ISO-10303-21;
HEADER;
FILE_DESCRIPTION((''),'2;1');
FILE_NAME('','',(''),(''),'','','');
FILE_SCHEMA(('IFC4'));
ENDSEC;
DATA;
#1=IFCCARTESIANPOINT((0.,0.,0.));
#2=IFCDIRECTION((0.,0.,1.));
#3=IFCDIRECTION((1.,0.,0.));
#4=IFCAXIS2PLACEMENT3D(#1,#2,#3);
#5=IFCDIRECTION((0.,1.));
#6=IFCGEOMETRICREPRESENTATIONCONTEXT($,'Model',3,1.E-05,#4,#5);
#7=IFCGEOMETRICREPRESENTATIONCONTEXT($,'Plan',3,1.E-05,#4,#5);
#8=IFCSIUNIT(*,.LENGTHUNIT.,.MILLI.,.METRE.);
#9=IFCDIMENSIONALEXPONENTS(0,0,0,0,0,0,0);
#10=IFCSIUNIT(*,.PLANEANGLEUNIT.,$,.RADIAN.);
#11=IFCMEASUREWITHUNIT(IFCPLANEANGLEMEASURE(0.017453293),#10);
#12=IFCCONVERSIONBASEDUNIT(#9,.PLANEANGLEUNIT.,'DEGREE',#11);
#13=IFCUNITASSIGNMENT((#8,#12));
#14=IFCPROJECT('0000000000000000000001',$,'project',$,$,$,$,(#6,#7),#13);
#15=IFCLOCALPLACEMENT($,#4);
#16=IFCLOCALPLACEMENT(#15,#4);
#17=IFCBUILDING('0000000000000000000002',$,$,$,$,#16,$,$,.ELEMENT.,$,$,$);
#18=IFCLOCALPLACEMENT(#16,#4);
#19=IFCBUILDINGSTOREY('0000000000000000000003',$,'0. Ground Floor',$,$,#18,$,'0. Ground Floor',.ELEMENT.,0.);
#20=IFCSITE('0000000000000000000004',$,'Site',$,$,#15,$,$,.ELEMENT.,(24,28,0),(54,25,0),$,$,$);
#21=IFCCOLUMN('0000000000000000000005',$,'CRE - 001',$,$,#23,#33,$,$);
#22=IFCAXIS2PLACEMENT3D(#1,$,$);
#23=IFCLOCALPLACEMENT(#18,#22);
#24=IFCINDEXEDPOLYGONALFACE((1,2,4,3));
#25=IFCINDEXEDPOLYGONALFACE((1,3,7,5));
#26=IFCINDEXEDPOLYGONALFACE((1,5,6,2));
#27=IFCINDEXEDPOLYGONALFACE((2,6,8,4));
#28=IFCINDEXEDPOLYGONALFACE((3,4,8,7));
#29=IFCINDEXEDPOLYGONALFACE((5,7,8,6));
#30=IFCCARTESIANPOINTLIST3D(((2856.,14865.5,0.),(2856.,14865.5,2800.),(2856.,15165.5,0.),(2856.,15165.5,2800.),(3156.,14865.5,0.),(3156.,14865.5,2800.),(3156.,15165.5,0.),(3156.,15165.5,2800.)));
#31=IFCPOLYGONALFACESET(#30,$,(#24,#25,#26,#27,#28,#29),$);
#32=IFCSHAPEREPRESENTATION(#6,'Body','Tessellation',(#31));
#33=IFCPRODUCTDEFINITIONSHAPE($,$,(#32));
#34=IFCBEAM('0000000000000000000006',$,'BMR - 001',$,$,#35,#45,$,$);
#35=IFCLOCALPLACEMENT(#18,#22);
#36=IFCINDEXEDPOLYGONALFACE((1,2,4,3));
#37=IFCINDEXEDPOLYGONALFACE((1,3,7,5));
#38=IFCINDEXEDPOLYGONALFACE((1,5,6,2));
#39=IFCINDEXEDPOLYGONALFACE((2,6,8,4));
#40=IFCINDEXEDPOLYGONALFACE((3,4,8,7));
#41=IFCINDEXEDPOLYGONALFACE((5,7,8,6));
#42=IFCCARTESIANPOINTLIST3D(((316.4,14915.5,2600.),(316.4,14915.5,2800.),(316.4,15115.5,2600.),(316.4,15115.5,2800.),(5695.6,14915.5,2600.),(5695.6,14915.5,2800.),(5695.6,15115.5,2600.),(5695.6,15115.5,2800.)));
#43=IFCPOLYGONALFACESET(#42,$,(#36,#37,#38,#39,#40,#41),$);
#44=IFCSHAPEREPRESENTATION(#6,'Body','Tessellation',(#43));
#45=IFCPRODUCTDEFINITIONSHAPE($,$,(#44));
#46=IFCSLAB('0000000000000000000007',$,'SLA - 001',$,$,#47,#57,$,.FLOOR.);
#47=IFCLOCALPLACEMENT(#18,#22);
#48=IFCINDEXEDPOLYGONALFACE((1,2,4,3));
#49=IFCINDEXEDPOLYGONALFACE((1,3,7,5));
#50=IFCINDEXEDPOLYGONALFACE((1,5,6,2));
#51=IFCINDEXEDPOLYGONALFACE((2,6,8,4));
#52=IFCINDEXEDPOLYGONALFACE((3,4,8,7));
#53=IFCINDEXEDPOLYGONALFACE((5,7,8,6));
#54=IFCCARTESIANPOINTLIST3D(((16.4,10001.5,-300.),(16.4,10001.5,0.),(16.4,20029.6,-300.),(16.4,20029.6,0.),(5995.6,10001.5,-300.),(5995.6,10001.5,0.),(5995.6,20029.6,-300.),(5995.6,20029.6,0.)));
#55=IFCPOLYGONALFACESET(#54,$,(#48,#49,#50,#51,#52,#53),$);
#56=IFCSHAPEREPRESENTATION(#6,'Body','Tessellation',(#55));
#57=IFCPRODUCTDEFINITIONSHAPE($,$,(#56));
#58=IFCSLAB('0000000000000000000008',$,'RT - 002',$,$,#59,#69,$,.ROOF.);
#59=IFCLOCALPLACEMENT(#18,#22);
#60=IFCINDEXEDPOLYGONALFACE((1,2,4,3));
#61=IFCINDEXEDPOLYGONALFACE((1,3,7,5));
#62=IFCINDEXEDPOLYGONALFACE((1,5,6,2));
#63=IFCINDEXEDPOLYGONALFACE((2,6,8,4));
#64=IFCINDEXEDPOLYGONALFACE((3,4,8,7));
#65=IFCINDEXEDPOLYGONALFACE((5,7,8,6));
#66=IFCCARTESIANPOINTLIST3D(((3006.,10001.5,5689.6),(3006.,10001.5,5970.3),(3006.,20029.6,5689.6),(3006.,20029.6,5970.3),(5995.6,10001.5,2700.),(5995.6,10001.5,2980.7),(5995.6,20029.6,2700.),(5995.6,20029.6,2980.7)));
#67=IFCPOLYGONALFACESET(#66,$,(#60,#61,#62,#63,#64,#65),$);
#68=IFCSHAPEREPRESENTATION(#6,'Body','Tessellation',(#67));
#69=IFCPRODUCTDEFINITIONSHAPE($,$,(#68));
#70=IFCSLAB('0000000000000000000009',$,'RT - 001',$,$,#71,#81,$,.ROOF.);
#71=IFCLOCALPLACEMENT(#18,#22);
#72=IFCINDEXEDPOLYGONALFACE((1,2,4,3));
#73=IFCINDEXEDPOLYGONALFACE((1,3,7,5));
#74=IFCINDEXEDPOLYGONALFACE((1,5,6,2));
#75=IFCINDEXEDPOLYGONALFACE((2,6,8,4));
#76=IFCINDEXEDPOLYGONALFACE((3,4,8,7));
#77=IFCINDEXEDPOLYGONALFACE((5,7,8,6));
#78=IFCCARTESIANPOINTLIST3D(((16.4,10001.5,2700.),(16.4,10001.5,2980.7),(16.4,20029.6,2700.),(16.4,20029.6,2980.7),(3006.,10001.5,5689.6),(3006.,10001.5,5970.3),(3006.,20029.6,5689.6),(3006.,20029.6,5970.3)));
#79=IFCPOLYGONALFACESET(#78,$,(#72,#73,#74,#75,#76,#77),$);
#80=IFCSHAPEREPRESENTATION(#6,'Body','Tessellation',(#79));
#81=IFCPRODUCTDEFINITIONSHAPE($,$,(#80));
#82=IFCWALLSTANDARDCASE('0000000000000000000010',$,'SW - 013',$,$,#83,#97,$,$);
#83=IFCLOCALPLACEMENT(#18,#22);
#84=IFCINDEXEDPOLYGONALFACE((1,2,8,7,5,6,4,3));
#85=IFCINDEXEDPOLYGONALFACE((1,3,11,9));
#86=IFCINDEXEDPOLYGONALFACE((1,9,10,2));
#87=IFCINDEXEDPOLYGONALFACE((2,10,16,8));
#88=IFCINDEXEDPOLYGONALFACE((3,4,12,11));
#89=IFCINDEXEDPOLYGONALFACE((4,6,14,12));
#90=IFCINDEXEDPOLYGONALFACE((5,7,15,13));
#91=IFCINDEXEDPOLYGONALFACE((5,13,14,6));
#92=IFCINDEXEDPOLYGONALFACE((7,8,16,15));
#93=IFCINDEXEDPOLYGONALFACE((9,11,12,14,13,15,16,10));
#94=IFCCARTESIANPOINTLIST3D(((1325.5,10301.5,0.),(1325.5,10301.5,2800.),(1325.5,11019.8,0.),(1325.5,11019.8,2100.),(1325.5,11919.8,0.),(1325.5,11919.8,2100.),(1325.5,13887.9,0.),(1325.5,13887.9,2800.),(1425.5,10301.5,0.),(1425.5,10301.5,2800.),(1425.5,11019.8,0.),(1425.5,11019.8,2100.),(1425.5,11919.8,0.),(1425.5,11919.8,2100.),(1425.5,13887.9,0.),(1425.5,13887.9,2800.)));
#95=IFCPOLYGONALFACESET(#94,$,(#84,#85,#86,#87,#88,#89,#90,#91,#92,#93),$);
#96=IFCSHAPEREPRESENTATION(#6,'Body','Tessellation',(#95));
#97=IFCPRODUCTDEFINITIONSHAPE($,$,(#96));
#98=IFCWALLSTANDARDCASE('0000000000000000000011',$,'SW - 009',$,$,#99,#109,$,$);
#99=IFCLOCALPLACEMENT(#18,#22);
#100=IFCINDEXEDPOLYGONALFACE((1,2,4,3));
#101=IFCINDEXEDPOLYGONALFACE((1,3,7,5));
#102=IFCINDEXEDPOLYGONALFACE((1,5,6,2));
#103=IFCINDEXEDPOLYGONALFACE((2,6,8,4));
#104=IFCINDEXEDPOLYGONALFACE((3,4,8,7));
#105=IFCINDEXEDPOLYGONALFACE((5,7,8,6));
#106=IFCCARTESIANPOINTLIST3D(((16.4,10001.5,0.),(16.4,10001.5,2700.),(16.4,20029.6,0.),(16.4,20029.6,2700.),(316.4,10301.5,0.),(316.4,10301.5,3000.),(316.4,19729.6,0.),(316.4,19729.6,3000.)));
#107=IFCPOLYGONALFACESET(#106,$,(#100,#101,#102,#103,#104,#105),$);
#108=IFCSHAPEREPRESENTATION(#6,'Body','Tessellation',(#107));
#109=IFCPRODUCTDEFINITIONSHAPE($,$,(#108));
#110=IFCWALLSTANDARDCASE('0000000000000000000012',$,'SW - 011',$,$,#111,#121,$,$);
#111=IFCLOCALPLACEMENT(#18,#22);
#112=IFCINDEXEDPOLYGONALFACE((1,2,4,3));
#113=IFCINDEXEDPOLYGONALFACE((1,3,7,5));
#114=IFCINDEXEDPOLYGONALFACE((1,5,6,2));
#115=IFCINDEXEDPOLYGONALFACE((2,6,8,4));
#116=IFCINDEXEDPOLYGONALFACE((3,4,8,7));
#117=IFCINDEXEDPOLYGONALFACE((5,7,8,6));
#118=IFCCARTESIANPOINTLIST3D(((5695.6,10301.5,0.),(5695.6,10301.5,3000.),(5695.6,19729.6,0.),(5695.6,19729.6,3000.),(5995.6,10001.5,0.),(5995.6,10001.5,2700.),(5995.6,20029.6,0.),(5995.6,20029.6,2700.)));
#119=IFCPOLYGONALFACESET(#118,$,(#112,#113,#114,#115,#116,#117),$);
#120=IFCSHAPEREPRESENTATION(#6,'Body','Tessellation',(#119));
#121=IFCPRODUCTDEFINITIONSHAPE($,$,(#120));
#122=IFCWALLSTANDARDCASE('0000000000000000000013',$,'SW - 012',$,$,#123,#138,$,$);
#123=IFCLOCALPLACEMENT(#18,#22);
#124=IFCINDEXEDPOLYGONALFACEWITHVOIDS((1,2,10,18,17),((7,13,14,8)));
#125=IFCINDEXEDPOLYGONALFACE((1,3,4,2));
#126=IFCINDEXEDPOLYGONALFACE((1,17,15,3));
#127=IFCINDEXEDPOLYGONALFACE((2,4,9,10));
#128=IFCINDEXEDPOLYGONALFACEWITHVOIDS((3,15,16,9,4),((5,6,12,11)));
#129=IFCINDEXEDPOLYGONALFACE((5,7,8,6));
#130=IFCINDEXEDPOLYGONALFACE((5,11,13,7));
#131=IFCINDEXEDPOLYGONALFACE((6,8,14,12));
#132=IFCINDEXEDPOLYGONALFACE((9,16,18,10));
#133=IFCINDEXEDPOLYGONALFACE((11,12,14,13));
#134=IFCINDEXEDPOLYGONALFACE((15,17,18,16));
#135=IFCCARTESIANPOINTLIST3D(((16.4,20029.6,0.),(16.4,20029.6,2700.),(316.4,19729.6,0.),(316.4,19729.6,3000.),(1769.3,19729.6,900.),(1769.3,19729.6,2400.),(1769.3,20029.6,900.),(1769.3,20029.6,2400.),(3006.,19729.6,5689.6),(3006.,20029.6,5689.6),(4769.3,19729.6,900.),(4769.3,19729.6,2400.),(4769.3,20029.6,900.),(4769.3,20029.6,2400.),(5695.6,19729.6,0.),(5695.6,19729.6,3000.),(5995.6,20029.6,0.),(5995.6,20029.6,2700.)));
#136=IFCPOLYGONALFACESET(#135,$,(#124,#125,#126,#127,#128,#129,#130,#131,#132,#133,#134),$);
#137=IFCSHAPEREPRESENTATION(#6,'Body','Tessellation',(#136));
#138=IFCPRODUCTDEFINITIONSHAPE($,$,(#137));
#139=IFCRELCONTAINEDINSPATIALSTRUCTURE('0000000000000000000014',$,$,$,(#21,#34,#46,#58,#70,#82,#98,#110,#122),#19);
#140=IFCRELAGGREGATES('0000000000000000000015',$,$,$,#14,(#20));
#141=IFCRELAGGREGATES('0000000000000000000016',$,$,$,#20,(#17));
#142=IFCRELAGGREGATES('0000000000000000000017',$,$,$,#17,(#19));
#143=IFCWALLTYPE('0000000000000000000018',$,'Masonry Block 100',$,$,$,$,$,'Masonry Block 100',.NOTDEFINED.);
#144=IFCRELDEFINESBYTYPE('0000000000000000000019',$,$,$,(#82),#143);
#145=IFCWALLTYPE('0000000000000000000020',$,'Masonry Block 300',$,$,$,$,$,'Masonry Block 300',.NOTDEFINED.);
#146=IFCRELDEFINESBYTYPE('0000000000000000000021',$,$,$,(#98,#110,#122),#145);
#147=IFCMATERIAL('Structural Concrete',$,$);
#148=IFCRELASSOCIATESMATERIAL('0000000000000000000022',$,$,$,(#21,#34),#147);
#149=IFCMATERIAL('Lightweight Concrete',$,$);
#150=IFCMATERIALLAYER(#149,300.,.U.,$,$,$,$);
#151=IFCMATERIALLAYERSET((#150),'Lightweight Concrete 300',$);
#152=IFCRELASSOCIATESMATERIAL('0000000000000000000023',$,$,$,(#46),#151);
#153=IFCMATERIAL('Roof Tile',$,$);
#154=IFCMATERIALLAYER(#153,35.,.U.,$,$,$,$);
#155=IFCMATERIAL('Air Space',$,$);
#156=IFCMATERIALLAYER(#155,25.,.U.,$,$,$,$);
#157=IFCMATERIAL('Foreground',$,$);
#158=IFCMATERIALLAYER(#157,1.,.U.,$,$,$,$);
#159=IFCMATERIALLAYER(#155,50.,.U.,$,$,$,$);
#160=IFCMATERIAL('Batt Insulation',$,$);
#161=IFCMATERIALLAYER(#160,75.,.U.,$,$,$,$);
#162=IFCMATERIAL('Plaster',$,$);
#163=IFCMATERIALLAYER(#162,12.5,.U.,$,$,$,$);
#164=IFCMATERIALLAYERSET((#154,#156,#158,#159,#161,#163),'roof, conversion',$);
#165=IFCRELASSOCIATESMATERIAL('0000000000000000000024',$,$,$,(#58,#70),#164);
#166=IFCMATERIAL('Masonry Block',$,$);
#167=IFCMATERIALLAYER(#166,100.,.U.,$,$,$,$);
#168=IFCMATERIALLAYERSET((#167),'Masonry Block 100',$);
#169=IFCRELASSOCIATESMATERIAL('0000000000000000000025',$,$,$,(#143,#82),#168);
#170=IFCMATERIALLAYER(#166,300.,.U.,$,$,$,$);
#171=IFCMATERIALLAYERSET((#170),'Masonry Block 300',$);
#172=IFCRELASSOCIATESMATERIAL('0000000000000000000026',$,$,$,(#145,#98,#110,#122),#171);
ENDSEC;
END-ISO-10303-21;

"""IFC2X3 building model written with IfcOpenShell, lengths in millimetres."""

from ifc_helpers import new_model, entity, si_unit, converted_unit, direction, frame, frame_2d, origin_with_axes, origin_2d_with_axis, place, context, project, spatial, polyline, rectangle, outline, extrude, clip, halfspace, bounded_halfspace, material, layer, layer_set, layer_usage, type_object, element, save


model = new_model("IFC2X3")

# Units and contexts
plan_context = context("Plan", 3, precision=1e-05, world=origin_with_axes(), true_north=direction((0.0, 1.0)))
model_context = context("Model", 3, precision=1e-05, world=origin_with_axes(), true_north=direction((0.0, 1.0)))
ifc_project = project(units=[si_unit("LENGTHUNIT", "METRE", prefix="MILLI"), converted_unit("PLANEANGLEUNIT", "DEGREE", entity("IfcPlaneAngleMeasure", 0.017453293), si_unit("PLANEANGLEUNIT", "RADIAN"), dimensions=[0, 0, 0, 0, 0, 0, 0])], contexts=[model_context, plan_context])

# Site, building, storey
site_placement = place(None, origin_with_axes())
site = spatial("IfcSite", under=ifc_project, at=site_placement, Name="Site", CompositionType="ELEMENT", RefLatitude=(24, 28, 0), RefLongitude=(54, 25, 0))
building_placement = place(site_placement, origin_with_axes())
building = spatial("IfcBuilding", under=site, at=building_placement, CompositionType="ELEMENT")
storey_placement = place(building_placement, origin_with_axes())
storey = spatial("IfcBuildingStorey", under=building, at=storey_placement, Name="0. Ground Floor", LongName="0. Ground Floor", CompositionType="ELEMENT", Elevation=0.0)

# Column
ifc_material_1 = material(Name="Structural Concrete")
column_placement = place(storey_placement, frame((3006.0, 15015.5, 0.0), z_axis=(0.0, 0.0, 1.0), x_axis=(1.0, 0.0, 0.0)))
element("IfcColumn", 1, at=column_placement, inside=storey, material=ifc_material_1, Name="CRE - 001", context=model_context, shape_type="SweptSolid", body=[
    extrude(rectangle(XDim=300.0, YDim=300.0, at=origin_2d_with_axis()), origin_with_axes(), (0.0, 0.0, 1.0), 2800.0),
])

# Beam
beam_placement = place(storey_placement, frame((316.4, 15015.5, 2800.0), z_axis=(0.0, 0.0, 1.0), x_axis=(0.0, -1.0, 0.0)))
element("IfcBeam", 2, at=beam_placement, inside=storey, material=ifc_material_1, Name="BMR - 001", context=model_context, shape_type="SweptSolid", body=[
    extrude(rectangle(XDim=200.0, YDim=200.0, at=frame_2d((-100.0, 0.0), x_axis=(1.0, 0.0))), frame((0.0, 0.0, 0.0), z_axis=(0.0, 1.0, 0.0), x_axis=(0.0, 0.0, 1.0)), (0.0, 0.0, 1.0), 5379.1),
])

# Slabs
ifc_material_2 = material(Name="Lightweight Concrete")
ifc_layer_1 = layer(ifc_material_2, 300.0, ventilated="UNKNOWN")
ifc_layer_set_1 = layer_set([ifc_layer_1], Name="Lightweight Concrete 300")
ifc_layer_usage_1 = layer_usage(ifc_layer_set_1, "AXIS3", "NEGATIVE", 300.0)
slab_1_placement = place(storey_placement, frame((16.4, 20029.6, -300.0), z_axis=(0.0, 0.0, 1.0), x_axis=(1.0, 0.0, 0.0)))
element("IfcSlab", 3, at=slab_1_placement, inside=storey, material=ifc_layer_usage_1, Name="SLA - 001", PredefinedType="FLOOR", context=model_context, shape_type="SweptSolid", body=[
    extrude(outline(polyline([(0.0, 0.0), (5979.1, 0.0), (5979.1, -10028.0), (0.0, -10028.0), (0.0, 0.0)])), origin_with_axes(), (0.0, 0.0, 1.0), 300.0),
])
ifc_material_3 = material(Name="Roof Tile")
ifc_layer_2 = layer(ifc_material_3, 35.0, ventilated="UNKNOWN")
ifc_material_4 = material(Name="Air Space")
ifc_layer_3 = layer(ifc_material_4, 25.0, ventilated="UNKNOWN")
ifc_material_5 = material(Name="Foreground")
ifc_layer_4 = layer(ifc_material_5, 1.0, ventilated="UNKNOWN")
ifc_layer_5 = layer(ifc_material_4, 50.0, ventilated="UNKNOWN")
ifc_material_6 = material(Name="Batt Insulation")
ifc_layer_6 = layer(ifc_material_6, 75.0, ventilated="UNKNOWN")
ifc_material_7 = material(Name="Plaster")
ifc_layer_7 = layer(ifc_material_7, 12.5, ventilated="UNKNOWN")
ifc_layer_set_2 = layer_set([ifc_layer_2, ifc_layer_3, ifc_layer_4, ifc_layer_5, ifc_layer_6, ifc_layer_7], Name="roof, conversion")
ifc_layer_usage_2 = layer_usage(ifc_layer_set_2, "AXIS3", "NEGATIVE", 198.5)
slab_2_placement = place(storey_placement, frame((5995.6, 10001.5, 2700.0), z_axis=(0.707107, 0.0, 0.707107), x_axis=(0.0, 1.0, 0.0)))
element("IfcSlab", 4, at=slab_2_placement, inside=storey, material=ifc_layer_usage_2, Name="RT - 002", PredefinedType="ROOF", context=model_context, shape_type="SweptSolid", body=[
    extrude(outline(polyline([(0.0, 0.0), (10028.0, 0.0), (10028.0, 4227.9), (0.0, 4227.9), (0.0, 0.0)])), origin_with_axes(), (0.0, 0.707107, 0.707107), 280.7),
])
ifc_layer_usage_3 = layer_usage(ifc_layer_set_2, "AXIS3", "NEGATIVE", 198.5)
slab_3_placement = place(storey_placement, frame((16.4, 20029.6, 2700.0), z_axis=(-0.707107, 0.0, 0.707107), x_axis=(0.0, -1.0, 0.0)))
element("IfcSlab", 5, at=slab_3_placement, inside=storey, material=ifc_layer_usage_3, Name="RT - 001", PredefinedType="ROOF", context=model_context, shape_type="SweptSolid", body=[
    extrude(outline(polyline([(0.0, 0.0), (0.0, 4227.9), (10028.0, 4227.9), (10028.0, 0.0), (0.0, 0.0)])), origin_with_axes(), (0.0, 0.707107, 0.707107), 280.7),
])

# Wall, opening
ifc_material_8 = material(Name="Masonry Block")
ifc_layer_8 = layer(ifc_material_8, 100.0, ventilated="UNKNOWN")
ifc_layer_set_3 = layer_set([ifc_layer_8], Name="Masonry Block 100")
ifc_layer_usage_4 = layer_usage(ifc_layer_set_3, "AXIS2", "POSITIVE", 0.0)
wall_type_1 = type_object("IfcWallType", Name="Masonry Block 100", ElementType="Masonry Block 100", PredefinedType="NOTDEFINED", material=ifc_layer_set_3)
wall_1_placement = place(storey_placement, frame((1325.5, 13887.9, 0.0), z_axis=(0.0, 0.0, 1.0), x_axis=(0.0, -1.0, 0.0)))
wall_1 = element("IfcWallStandardCase", 6, at=wall_1_placement, inside=storey, type_object=wall_type_1, material=ifc_layer_usage_4, Name="SW - 013", context=model_context, shape_type="SweptSolid", body=[
    extrude(outline(polyline([(0.0, 0.0), (3586.4, 0.0), (3586.4, 100.0), (0.0, 100.0), (0.0, 0.0)])), origin_with_axes(), (0.0, 0.0, 1.0), 2800.0),
])
opening_1_placement = place(wall_1_placement, frame((2418.1, 0.0, 0.0), z_axis=(0.0, 0.0, 1.0), x_axis=(1.0, 0.0, 0.0)))
element("IfcOpeningElement", 7, at=opening_1_placement, cuts=wall_1, ObjectType="Opening", context=model_context, shape_type="SweptSolid", body=[
    extrude(rectangle(XDim=900.0, YDim=2100.0, at=frame_2d((0.0, 1050.0), x_axis=(-1.0, 0.0))), frame((0.0, 0.0, 0.0), z_axis=(0.0, 1.0, 0.0), x_axis=(-1.0, 0.0, 0.0)), (0.0, 0.0, 1.0), 100.0),
])

# Walls
ifc_layer_9 = layer(ifc_material_8, 300.0, ventilated="UNKNOWN")
ifc_layer_set_4 = layer_set([ifc_layer_9], Name="Masonry Block 300")
ifc_layer_usage_5 = layer_usage(ifc_layer_set_4, "AXIS2", "POSITIVE", 0.0)
wall_type_2 = type_object("IfcWallType", Name="Masonry Block 300", ElementType="Masonry Block 300", PredefinedType="NOTDEFINED", material=ifc_layer_set_4)
wall_2_placement = place(storey_placement, frame((16.4, 20029.6, 0.0), z_axis=(0.0, 0.0, 1.0), x_axis=(0.0, -1.0, 0.0)))
element("IfcWallStandardCase", 8, at=wall_2_placement, inside=storey, type_object=wall_type_2, material=ifc_layer_usage_5, Name="SW - 009", context=model_context, shape_type="Clipping", body=[
    clip(extrude(outline(polyline([(0.0, 0.0), (10028.0, 0.0), (9728.0, 300.0), (300.0, 300.0), (0.0, 0.0)])), origin_with_axes(), (0.0, 0.0, 1.0), 6000.0), halfspace(frame((0.0, -1350.0, 1350.0), z_axis=(0.0, 0.707107, -0.707107), x_axis=(0.0, 0.707107, 0.707107)), True)),
])
ifc_layer_usage_6 = layer_usage(ifc_layer_set_4, "AXIS2", "POSITIVE", 0.0)
wall_3_placement = place(storey_placement, frame((5995.6, 10001.5, 0.0), z_axis=(0.0, 0.0, 1.0), x_axis=(0.0, 1.0, 0.0)))
element("IfcWallStandardCase", 9, at=wall_3_placement, inside=storey, type_object=wall_type_2, material=ifc_layer_usage_6, Name="SW - 011", context=model_context, shape_type="Clipping", body=[
    clip(extrude(outline(polyline([(0.0, 0.0), (10028.0, 0.0), (9728.0, 300.0), (300.0, 300.0), (0.0, 0.0)])), origin_with_axes(), (0.0, 0.0, 1.0), 6000.0), halfspace(frame((0.0, -1350.0, 1350.0), z_axis=(0.0, 0.707107, -0.707107), x_axis=(0.0, 0.707107, 0.707107)), True)),
])

# Wall, opening
ifc_layer_usage_7 = layer_usage(ifc_layer_set_4, "AXIS2", "POSITIVE", 0.0)
wall_4_placement = place(storey_placement, frame((5995.6, 20029.6, 0.0), z_axis=(0.0, 0.0, 1.0), x_axis=(-1.0, 0.0, 0.0)))
wall_4 = element("IfcWallStandardCase", 10, at=wall_4_placement, inside=storey, type_object=wall_type_2, material=ifc_layer_usage_7, Name="SW - 012", context=model_context, shape_type="Clipping", body=[
    clip(clip(extrude(outline(polyline([(0.0, 0.0), (5979.1, 0.0), (5679.1, 300.0), (300.0, 300.0), (0.0, 0.0)])), origin_with_axes(), (0.0, 0.0, 1.0), 6000.0), bounded_halfspace(frame((4339.6, 0.0, 4339.6), z_axis=(-0.707107, 0.0, -0.707107), x_axis=(0.0, 1.0, 0.0)), True, origin_with_axes(), polyline([(2989.6, -150.0), (2989.6, 450.0), (5989.1, 450.0), (5989.1, -150.0), (2989.6, -150.0)]))), bounded_halfspace(frame((-1350.0, 0.0, 1350.0), z_axis=(0.707107, 0.0, -0.707107), x_axis=(0.0, 1.0, 0.0)), True, origin_with_axes(), polyline([(2989.6, -150.0), (2989.6, 450.0), (-10.0, 450.0), (-10.0, -150.0), (2989.6, -150.0)]))),
])
opening_2_placement = place(wall_4_placement, frame((2726.3, 0.0, 900.0), z_axis=(0.0, 0.0, 1.0), x_axis=(1.0, 0.0, 0.0)))
element("IfcOpeningElement", 11, at=opening_2_placement, cuts=wall_4, ObjectType="Opening", context=model_context, shape_type="SweptSolid", body=[
    extrude(rectangle(XDim=3000.0, YDim=1500.0, at=frame_2d((0.0, 750.0), x_axis=(1.0, 0.0))), frame((0.0, 0.0, 0.0), z_axis=(0.0, 1.0, 0.0), x_axis=(-1.0, 0.0, 0.0)), (0.0, 0.0, 1.0), 300.0),
])

save(model, "model.ifc")
